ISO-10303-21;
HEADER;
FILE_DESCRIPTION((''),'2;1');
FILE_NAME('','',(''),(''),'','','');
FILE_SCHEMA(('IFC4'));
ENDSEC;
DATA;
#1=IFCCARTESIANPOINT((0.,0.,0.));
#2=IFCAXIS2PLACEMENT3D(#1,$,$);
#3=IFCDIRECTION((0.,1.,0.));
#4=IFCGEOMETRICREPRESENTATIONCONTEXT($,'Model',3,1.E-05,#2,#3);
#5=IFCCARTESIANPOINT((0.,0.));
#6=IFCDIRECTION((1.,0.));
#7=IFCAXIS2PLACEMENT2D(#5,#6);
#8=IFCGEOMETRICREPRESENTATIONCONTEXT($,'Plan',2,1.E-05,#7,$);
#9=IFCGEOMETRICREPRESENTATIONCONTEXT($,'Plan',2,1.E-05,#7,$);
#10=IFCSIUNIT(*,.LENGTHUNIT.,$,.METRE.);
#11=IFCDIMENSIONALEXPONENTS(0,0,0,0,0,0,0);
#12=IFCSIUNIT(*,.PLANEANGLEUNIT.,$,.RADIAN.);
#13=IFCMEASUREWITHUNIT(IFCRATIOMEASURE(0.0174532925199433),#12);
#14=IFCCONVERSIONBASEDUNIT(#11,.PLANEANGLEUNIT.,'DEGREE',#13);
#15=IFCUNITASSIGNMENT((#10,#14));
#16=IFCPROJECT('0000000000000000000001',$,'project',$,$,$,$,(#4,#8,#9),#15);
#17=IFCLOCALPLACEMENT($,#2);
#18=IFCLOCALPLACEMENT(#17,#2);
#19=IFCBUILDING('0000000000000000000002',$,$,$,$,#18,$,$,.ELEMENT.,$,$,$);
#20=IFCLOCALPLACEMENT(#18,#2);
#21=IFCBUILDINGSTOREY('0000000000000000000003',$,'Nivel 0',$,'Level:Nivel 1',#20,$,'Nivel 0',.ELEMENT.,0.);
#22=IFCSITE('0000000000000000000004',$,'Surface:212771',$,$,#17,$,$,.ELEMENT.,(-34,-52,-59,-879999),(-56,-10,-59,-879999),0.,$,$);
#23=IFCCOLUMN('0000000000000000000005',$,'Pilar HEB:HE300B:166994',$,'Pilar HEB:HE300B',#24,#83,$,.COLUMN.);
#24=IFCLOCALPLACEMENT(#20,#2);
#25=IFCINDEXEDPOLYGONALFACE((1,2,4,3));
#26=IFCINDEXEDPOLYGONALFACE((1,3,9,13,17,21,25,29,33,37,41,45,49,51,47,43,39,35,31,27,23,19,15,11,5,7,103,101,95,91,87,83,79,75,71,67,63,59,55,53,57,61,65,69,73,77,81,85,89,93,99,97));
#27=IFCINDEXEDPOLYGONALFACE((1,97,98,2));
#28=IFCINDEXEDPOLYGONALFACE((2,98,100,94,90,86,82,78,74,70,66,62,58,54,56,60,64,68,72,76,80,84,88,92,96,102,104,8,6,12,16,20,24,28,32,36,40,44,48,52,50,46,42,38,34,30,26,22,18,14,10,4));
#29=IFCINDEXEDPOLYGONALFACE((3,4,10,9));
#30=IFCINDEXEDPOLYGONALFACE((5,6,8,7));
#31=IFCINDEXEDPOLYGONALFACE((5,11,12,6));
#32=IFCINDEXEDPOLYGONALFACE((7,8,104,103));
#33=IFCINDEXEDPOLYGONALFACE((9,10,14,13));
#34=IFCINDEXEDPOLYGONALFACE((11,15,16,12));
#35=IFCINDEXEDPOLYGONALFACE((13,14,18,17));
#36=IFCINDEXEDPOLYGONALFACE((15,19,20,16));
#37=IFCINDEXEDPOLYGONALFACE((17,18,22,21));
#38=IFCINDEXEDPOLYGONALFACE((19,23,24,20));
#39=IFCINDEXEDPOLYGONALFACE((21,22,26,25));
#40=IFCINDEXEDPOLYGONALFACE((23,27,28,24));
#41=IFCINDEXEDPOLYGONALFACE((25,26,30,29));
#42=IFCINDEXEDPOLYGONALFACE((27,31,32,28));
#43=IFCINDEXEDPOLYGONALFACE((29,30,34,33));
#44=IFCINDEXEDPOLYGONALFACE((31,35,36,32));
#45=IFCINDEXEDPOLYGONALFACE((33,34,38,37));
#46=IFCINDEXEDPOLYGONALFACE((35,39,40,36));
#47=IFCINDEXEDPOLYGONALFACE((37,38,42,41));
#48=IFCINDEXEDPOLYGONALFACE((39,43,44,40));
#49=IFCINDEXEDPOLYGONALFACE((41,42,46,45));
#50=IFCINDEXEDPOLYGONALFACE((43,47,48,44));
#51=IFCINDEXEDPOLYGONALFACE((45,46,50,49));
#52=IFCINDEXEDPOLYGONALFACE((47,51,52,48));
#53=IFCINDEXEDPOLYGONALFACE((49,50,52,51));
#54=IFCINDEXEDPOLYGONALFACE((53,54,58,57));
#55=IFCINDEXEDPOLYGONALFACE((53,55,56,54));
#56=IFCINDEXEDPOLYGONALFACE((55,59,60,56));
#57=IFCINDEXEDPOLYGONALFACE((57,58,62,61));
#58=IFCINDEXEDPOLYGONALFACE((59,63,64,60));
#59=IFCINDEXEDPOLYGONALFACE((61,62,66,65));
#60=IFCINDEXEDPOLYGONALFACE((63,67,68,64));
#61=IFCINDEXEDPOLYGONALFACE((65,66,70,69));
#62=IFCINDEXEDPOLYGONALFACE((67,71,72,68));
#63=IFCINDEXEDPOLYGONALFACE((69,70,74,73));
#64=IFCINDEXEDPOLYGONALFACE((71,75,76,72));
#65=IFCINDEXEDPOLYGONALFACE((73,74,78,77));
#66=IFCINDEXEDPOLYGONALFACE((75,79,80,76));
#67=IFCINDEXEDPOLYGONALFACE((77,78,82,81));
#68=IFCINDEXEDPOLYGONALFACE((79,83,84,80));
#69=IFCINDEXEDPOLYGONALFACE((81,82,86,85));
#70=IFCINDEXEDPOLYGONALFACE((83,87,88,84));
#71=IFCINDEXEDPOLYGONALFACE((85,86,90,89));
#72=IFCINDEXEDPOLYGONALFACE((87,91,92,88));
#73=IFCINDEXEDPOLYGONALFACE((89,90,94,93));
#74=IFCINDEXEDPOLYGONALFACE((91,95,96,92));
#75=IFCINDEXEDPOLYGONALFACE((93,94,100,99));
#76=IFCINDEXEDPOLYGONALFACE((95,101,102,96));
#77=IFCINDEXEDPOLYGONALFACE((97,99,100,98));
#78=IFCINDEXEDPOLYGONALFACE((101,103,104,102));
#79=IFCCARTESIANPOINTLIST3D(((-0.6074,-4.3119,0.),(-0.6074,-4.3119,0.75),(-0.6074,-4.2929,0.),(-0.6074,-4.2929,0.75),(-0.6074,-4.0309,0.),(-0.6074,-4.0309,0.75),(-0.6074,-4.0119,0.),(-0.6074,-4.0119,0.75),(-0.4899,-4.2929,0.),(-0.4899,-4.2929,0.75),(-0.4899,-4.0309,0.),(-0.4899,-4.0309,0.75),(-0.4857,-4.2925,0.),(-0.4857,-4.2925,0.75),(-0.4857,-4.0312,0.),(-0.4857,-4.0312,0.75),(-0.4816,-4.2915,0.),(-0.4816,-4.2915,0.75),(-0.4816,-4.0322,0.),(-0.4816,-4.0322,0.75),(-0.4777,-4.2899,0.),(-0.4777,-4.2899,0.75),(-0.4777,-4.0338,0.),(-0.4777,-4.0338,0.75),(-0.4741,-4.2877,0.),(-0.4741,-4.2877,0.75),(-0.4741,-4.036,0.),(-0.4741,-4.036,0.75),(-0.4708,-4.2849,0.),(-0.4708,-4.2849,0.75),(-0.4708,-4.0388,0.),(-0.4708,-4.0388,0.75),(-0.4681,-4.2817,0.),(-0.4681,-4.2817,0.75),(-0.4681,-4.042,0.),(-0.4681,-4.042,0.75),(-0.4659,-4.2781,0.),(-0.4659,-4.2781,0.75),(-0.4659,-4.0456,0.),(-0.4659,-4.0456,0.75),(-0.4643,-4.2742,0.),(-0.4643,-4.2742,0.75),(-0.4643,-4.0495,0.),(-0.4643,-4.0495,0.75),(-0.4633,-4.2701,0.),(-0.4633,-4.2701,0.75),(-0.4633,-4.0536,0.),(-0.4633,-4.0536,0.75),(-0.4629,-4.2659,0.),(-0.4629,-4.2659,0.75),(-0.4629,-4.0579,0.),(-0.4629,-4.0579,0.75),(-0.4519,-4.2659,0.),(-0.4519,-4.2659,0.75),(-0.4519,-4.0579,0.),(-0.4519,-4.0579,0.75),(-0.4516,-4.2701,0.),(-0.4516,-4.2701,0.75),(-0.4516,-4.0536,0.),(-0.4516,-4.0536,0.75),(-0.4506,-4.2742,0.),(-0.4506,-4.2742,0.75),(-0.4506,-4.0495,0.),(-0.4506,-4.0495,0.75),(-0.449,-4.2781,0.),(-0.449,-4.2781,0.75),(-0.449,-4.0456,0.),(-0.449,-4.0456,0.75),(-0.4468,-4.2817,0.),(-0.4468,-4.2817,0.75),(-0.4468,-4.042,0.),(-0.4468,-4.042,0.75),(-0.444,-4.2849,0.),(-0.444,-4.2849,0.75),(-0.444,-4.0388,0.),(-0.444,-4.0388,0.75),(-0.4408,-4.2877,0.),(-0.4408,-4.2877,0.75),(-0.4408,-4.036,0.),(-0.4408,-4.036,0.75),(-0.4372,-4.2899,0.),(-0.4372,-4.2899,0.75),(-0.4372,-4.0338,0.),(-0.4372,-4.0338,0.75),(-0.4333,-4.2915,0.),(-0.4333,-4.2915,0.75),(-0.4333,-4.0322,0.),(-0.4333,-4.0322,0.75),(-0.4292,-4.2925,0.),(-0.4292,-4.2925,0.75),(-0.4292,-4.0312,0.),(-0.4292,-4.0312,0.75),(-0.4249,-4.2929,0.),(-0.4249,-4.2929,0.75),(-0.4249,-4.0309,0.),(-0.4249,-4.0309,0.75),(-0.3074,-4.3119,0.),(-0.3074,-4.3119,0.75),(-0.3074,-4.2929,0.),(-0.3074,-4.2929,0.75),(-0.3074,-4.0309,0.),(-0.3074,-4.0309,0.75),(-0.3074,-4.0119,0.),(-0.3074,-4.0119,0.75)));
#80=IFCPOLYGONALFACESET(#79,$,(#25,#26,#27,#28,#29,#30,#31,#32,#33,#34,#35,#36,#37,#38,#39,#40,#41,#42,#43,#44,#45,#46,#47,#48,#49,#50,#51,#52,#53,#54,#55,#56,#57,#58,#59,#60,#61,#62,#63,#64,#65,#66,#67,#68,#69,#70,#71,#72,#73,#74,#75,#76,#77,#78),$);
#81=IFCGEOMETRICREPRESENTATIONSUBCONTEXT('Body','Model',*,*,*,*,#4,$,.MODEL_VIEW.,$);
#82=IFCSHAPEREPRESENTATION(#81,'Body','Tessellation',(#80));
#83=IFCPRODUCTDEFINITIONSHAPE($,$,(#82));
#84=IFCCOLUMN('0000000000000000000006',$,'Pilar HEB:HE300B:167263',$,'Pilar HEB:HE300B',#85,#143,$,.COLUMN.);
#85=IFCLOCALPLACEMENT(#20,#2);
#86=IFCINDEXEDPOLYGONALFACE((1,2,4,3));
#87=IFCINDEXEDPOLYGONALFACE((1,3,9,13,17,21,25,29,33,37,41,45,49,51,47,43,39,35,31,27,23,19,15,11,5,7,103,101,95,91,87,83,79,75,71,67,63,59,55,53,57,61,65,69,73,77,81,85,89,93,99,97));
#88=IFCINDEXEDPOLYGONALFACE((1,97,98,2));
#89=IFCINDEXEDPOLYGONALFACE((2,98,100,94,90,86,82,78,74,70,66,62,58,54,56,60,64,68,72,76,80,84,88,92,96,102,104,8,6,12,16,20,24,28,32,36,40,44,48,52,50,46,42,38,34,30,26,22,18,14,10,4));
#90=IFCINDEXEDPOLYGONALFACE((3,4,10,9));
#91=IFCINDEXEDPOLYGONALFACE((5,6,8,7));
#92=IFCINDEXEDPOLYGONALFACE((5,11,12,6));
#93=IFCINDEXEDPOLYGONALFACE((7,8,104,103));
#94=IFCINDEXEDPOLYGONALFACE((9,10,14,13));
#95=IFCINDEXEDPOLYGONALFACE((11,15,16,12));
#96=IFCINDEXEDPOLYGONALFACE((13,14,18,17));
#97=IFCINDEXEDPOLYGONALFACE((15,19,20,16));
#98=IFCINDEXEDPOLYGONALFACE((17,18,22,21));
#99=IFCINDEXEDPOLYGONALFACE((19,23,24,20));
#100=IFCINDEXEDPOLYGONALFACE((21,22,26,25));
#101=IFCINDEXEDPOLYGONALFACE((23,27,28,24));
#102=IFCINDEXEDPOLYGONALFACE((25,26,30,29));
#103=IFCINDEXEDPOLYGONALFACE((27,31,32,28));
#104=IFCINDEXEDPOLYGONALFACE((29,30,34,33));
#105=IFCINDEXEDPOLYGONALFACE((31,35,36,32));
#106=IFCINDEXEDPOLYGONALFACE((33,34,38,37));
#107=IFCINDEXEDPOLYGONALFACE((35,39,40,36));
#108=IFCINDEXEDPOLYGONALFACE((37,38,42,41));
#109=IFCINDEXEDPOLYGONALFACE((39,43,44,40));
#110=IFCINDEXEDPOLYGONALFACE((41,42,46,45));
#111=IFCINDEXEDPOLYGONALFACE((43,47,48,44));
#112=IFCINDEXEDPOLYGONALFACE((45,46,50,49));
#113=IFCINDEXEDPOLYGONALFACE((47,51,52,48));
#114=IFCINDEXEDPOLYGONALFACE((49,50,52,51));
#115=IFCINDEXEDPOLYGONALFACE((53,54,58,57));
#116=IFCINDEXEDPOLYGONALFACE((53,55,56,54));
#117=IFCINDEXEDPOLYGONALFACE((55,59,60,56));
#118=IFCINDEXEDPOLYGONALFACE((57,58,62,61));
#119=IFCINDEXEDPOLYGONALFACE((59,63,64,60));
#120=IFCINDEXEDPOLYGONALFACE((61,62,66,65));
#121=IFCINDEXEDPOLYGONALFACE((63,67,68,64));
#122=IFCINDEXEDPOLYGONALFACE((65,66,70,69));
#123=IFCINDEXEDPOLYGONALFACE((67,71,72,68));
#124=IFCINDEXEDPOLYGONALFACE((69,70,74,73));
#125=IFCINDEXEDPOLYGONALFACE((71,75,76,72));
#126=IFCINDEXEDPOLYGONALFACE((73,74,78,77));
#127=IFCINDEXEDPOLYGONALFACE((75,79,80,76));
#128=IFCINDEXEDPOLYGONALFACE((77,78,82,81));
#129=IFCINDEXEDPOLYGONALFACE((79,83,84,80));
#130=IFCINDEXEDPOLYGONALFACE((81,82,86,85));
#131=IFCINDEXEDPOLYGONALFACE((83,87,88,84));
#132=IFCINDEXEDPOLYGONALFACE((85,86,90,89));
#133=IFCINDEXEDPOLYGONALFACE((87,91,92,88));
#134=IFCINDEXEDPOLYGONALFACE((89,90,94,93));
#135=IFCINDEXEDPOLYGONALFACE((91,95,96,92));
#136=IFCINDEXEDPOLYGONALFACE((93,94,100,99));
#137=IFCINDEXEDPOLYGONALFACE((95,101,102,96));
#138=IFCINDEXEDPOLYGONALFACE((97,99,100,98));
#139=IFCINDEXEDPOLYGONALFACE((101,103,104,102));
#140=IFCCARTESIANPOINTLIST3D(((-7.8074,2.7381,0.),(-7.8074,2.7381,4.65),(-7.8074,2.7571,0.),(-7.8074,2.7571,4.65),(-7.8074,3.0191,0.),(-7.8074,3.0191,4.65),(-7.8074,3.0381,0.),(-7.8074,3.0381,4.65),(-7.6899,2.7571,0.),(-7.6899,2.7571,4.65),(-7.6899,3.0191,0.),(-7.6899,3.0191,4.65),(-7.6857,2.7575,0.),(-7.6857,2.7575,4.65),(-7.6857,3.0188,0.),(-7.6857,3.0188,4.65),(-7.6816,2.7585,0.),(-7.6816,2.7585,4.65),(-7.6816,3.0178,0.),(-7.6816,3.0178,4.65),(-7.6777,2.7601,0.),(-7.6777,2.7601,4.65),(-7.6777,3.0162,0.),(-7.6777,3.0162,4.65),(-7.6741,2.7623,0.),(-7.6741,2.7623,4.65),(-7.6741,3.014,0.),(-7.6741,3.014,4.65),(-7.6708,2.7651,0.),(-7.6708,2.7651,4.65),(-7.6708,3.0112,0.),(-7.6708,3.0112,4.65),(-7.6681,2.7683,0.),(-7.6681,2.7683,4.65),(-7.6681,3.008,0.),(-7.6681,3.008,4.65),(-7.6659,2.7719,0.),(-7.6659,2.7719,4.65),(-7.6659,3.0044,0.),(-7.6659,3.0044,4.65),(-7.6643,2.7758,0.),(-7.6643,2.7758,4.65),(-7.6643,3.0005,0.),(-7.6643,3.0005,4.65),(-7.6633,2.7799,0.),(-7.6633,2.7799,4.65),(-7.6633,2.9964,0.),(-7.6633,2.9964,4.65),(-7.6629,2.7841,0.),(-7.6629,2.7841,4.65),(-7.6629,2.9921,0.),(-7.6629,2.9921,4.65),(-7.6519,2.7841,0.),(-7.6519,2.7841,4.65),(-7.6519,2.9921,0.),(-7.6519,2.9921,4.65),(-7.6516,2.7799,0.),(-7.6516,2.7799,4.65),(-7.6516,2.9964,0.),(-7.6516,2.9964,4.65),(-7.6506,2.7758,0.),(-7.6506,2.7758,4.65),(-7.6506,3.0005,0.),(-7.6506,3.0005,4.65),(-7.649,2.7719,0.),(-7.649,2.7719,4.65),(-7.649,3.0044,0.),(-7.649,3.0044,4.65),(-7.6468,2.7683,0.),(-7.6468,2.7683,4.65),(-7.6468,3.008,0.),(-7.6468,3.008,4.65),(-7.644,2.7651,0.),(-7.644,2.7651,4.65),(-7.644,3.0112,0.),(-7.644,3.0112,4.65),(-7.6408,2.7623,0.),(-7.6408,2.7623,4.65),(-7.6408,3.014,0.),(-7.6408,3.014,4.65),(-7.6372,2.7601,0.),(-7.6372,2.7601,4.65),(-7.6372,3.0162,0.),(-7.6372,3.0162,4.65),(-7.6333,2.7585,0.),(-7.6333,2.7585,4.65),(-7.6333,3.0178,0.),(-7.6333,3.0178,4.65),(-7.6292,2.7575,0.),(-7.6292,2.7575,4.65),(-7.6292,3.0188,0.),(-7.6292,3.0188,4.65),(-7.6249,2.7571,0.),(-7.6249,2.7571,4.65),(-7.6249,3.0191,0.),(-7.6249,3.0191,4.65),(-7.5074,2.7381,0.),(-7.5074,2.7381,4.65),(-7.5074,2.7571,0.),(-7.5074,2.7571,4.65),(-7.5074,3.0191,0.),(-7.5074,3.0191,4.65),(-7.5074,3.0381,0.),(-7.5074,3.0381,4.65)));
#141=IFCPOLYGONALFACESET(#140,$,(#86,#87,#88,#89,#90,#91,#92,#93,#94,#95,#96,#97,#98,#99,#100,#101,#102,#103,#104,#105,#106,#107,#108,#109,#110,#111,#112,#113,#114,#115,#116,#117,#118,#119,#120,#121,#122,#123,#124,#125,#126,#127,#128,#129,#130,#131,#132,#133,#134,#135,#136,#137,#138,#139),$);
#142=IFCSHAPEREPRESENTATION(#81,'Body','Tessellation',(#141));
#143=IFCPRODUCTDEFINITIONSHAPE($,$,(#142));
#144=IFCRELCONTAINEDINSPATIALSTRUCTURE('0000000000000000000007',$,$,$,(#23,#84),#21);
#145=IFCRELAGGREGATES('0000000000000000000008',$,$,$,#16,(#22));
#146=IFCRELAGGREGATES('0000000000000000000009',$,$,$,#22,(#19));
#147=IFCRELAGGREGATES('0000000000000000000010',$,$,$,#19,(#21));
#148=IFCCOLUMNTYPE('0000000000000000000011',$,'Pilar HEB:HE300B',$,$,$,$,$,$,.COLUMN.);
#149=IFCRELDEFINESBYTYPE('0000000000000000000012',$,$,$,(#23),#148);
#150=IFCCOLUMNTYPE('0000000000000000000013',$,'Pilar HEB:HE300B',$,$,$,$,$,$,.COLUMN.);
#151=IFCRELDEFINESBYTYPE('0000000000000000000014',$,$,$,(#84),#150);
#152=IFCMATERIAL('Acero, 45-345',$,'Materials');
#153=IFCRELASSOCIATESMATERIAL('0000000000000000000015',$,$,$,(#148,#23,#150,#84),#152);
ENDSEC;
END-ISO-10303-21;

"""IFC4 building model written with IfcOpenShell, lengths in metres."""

from ifc_helpers import new_model, entity, si_unit, converted_unit, direction, frame, origin, origin_2d_with_axis, place, context, subcontext, project, spatial, polyline, outline, extrude, source, transform, mapped, material, type_object, type_shapes, element, save


model = new_model("IFC4")

# Units and contexts
model_context = context("Model", 3, precision=1e-05, world=origin(), true_north=direction((0.0, 1.0, 0.0)))
plan_context_1 = context("Plan", 2, precision=1e-05, world=origin_2d_with_axis())
plan_context_2 = context("Plan", 2, precision=1e-05, world=origin_2d_with_axis())
body_context = subcontext(model_context, "Body", "Model", "MODEL_VIEW")
ifc_project = project(units=[si_unit("LENGTHUNIT", "METRE"), converted_unit("PLANEANGLEUNIT", "DEGREE", entity("IfcRatioMeasure", 0.0174532925199433), si_unit("PLANEANGLEUNIT", "RADIAN"), dimensions=[0, 0, 0, 0, 0, 0, 0])], contexts=[model_context, plan_context_1, plan_context_2])

# Site, building, storey
site_placement = place(None, origin())
site = spatial("IfcSite", under=ifc_project, at=site_placement, Name="Surface:212771", CompositionType="ELEMENT", RefLatitude=(-34, -52, -59, -879999), RefLongitude=(-56, -10, -59, -879999), RefElevation=0.0)
building_placement = place(site_placement, origin())
building = spatial("IfcBuilding", under=site, at=building_placement, CompositionType="ELEMENT")
storey_placement = place(building_placement, origin())
storey = spatial("IfcBuildingStorey", under=building, at=storey_placement, Name="Nivel 0", ObjectType="Level:Nivel 1", LongName="Nivel 0", CompositionType="ELEMENT", Elevation=0.0)

# Columns
ifc_material_1 = material(Name="Acero, 45-345", Category="Materials")
column_type_1 = type_object("IfcColumnType", Name="Pilar HEB:HE300B", PredefinedType="COLUMN", material=ifc_material_1)
shared_shape_1 = source(origin(), body_context, "Body", "SweptSolid", [
    extrude(outline(polyline([(-0.104, -0.0055), (0.104, -0.0055), (0.1082, -0.0058), (0.1123, -0.0068), (0.1163, -0.0084), (0.1199, -0.0107), (0.1231, -0.0134), (0.1258, -0.0166), (0.1281, -0.0202), (0.1297, -0.0242), (0.1307, -0.0283), (0.131, -0.0325), (0.131, -0.15), (0.15, -0.15), (0.15, 0.15), (0.131, 0.15), (0.131, 0.0325), (0.1307, 0.0283), (0.1297, 0.0242), (0.1281, 0.0202), (0.1258, 0.0166), (0.1231, 0.0134), (0.1199, 0.0107), (0.1163, 0.0084), (0.1123, 0.0068), (0.1082, 0.0058), (0.104, 0.0055), (-0.104, 0.0055), (-0.1082, 0.0058), (-0.1123, 0.0068), (-0.1163, 0.0084), (-0.1199, 0.0107), (-0.1231, 0.0134), (-0.1258, 0.0166), (-0.1281, 0.0202), (-0.1297, 0.0242), (-0.1307, 0.0283), (-0.131, 0.0325), (-0.131, 0.15), (-0.15, 0.15), (-0.15, -0.15), (-0.131, -0.15), (-0.131, -0.0325), (-0.1307, -0.0283), (-0.1297, -0.0242), (-0.1281, -0.0202), (-0.1258, -0.0166), (-0.1231, -0.0134), (-0.1199, -0.0107), (-0.1163, -0.0084), (-0.1123, -0.0068), (-0.1082, -0.0058), (-0.104, -0.0055)])), frame((0.0, 0.0, 0.0), z_axis=(0.0, 0.0, -1.0), x_axis=(0.0, -1.0, 0.0)), (0.0, 0.0, -1.0), 0.75),
])
type_shapes(column_type_1, [shared_shape_1])
for number, where, name in (
    (1, (-0.4574, -4.1619, 0.0), "Pilar HEB:HE300B:166994"),
):
    element("IfcColumn", number, at=place(storey_placement, frame(where)), inside=storey, type_object=column_type_1, material=ifc_material_1, Name=name, ObjectType="Pilar HEB:HE300B", PredefinedType="COLUMN", context=body_context, shape_type="MappedRepresentation", body=[
        mapped(shared_shape_1, transform((0.0, 0.0, 0.0), scale=1.0)),
    ])
column_type_2 = type_object("IfcColumnType", Name="Pilar HEB:HE300B", PredefinedType="COLUMN", material=ifc_material_1)
shared_shape_2 = source(origin(), body_context, "Body", "SweptSolid", [
    extrude(outline(polyline([(0.1041, 0.0), (0.1084, -0.0001), (0.1125, -0.0009), (0.1165, -0.0023), (0.1203, -0.0043), (0.1236, -0.0069), (0.1265, -0.01), (0.1289, -0.0135), (0.1308, -0.0173), (0.132, -0.0213), (0.1325, -0.0255), (0.1387, -0.1429), (0.1577, -0.1419), (0.1419, 0.1577), (0.1229, 0.1567), (0.1291, 0.0394), (0.129, 0.0351), (0.1282, 0.031), (0.1268, 0.027), (0.1248, 0.0233), (0.1222, 0.0199), (0.1191, 0.017), (0.1156, 0.0146), (0.1118, 0.0127), (0.1078, 0.0115), (0.1036, 0.011), (-0.1041, 0.0), (-0.1084, 0.0001), (-0.1125, 0.0009), (-0.1165, 0.0023), (-0.1203, 0.0043), (-0.1236, 0.0069), (-0.1265, 0.01), (-0.1289, 0.0135), (-0.1308, 0.0173), (-0.132, 0.0213), (-0.1325, 0.0255), (-0.1387, 0.1429), (-0.1577, 0.1419), (-0.1419, -0.1577), (-0.1229, -0.1567), (-0.1291, -0.0394), (-0.129, -0.0351), (-0.1282, -0.031), (-0.1268, -0.027), (-0.1248, -0.0233), (-0.1222, -0.0199), (-0.1191, -0.017), (-0.1156, -0.0146), (-0.1118, -0.0127), (-0.1078, -0.0115), (-0.1036, -0.011), (0.1041, 0.0)])), frame((0.0, 0.0, 0.0), z_axis=(0.0, 0.0, -1.0), x_axis=(0.052811, -0.998605, 0.0)), (0.0, 0.0, -1.0), 4.65),
])
type_shapes(column_type_2, [shared_shape_2])
for number, where, z_axis, x_axis, name in (
    (2, (-7.6574, 2.8881, 0.0), (0.0, 0.0, 2.115501), (1.0, 0.0, 0.0), "Pilar HEB:HE300B:167263"),
):
    element("IfcColumn", number, at=place(storey_placement, frame(where, z_axis=z_axis, x_axis=x_axis)), inside=storey, type_object=column_type_2, material=ifc_material_1, Name=name, ObjectType="Pilar HEB:HE300B", PredefinedType="COLUMN", context=body_context, shape_type="MappedRepresentation", body=[
        mapped(shared_shape_2, transform((0.0, 0.0, 0.0), scale=1.0)),
    ])

save(model, "model.ifc")
